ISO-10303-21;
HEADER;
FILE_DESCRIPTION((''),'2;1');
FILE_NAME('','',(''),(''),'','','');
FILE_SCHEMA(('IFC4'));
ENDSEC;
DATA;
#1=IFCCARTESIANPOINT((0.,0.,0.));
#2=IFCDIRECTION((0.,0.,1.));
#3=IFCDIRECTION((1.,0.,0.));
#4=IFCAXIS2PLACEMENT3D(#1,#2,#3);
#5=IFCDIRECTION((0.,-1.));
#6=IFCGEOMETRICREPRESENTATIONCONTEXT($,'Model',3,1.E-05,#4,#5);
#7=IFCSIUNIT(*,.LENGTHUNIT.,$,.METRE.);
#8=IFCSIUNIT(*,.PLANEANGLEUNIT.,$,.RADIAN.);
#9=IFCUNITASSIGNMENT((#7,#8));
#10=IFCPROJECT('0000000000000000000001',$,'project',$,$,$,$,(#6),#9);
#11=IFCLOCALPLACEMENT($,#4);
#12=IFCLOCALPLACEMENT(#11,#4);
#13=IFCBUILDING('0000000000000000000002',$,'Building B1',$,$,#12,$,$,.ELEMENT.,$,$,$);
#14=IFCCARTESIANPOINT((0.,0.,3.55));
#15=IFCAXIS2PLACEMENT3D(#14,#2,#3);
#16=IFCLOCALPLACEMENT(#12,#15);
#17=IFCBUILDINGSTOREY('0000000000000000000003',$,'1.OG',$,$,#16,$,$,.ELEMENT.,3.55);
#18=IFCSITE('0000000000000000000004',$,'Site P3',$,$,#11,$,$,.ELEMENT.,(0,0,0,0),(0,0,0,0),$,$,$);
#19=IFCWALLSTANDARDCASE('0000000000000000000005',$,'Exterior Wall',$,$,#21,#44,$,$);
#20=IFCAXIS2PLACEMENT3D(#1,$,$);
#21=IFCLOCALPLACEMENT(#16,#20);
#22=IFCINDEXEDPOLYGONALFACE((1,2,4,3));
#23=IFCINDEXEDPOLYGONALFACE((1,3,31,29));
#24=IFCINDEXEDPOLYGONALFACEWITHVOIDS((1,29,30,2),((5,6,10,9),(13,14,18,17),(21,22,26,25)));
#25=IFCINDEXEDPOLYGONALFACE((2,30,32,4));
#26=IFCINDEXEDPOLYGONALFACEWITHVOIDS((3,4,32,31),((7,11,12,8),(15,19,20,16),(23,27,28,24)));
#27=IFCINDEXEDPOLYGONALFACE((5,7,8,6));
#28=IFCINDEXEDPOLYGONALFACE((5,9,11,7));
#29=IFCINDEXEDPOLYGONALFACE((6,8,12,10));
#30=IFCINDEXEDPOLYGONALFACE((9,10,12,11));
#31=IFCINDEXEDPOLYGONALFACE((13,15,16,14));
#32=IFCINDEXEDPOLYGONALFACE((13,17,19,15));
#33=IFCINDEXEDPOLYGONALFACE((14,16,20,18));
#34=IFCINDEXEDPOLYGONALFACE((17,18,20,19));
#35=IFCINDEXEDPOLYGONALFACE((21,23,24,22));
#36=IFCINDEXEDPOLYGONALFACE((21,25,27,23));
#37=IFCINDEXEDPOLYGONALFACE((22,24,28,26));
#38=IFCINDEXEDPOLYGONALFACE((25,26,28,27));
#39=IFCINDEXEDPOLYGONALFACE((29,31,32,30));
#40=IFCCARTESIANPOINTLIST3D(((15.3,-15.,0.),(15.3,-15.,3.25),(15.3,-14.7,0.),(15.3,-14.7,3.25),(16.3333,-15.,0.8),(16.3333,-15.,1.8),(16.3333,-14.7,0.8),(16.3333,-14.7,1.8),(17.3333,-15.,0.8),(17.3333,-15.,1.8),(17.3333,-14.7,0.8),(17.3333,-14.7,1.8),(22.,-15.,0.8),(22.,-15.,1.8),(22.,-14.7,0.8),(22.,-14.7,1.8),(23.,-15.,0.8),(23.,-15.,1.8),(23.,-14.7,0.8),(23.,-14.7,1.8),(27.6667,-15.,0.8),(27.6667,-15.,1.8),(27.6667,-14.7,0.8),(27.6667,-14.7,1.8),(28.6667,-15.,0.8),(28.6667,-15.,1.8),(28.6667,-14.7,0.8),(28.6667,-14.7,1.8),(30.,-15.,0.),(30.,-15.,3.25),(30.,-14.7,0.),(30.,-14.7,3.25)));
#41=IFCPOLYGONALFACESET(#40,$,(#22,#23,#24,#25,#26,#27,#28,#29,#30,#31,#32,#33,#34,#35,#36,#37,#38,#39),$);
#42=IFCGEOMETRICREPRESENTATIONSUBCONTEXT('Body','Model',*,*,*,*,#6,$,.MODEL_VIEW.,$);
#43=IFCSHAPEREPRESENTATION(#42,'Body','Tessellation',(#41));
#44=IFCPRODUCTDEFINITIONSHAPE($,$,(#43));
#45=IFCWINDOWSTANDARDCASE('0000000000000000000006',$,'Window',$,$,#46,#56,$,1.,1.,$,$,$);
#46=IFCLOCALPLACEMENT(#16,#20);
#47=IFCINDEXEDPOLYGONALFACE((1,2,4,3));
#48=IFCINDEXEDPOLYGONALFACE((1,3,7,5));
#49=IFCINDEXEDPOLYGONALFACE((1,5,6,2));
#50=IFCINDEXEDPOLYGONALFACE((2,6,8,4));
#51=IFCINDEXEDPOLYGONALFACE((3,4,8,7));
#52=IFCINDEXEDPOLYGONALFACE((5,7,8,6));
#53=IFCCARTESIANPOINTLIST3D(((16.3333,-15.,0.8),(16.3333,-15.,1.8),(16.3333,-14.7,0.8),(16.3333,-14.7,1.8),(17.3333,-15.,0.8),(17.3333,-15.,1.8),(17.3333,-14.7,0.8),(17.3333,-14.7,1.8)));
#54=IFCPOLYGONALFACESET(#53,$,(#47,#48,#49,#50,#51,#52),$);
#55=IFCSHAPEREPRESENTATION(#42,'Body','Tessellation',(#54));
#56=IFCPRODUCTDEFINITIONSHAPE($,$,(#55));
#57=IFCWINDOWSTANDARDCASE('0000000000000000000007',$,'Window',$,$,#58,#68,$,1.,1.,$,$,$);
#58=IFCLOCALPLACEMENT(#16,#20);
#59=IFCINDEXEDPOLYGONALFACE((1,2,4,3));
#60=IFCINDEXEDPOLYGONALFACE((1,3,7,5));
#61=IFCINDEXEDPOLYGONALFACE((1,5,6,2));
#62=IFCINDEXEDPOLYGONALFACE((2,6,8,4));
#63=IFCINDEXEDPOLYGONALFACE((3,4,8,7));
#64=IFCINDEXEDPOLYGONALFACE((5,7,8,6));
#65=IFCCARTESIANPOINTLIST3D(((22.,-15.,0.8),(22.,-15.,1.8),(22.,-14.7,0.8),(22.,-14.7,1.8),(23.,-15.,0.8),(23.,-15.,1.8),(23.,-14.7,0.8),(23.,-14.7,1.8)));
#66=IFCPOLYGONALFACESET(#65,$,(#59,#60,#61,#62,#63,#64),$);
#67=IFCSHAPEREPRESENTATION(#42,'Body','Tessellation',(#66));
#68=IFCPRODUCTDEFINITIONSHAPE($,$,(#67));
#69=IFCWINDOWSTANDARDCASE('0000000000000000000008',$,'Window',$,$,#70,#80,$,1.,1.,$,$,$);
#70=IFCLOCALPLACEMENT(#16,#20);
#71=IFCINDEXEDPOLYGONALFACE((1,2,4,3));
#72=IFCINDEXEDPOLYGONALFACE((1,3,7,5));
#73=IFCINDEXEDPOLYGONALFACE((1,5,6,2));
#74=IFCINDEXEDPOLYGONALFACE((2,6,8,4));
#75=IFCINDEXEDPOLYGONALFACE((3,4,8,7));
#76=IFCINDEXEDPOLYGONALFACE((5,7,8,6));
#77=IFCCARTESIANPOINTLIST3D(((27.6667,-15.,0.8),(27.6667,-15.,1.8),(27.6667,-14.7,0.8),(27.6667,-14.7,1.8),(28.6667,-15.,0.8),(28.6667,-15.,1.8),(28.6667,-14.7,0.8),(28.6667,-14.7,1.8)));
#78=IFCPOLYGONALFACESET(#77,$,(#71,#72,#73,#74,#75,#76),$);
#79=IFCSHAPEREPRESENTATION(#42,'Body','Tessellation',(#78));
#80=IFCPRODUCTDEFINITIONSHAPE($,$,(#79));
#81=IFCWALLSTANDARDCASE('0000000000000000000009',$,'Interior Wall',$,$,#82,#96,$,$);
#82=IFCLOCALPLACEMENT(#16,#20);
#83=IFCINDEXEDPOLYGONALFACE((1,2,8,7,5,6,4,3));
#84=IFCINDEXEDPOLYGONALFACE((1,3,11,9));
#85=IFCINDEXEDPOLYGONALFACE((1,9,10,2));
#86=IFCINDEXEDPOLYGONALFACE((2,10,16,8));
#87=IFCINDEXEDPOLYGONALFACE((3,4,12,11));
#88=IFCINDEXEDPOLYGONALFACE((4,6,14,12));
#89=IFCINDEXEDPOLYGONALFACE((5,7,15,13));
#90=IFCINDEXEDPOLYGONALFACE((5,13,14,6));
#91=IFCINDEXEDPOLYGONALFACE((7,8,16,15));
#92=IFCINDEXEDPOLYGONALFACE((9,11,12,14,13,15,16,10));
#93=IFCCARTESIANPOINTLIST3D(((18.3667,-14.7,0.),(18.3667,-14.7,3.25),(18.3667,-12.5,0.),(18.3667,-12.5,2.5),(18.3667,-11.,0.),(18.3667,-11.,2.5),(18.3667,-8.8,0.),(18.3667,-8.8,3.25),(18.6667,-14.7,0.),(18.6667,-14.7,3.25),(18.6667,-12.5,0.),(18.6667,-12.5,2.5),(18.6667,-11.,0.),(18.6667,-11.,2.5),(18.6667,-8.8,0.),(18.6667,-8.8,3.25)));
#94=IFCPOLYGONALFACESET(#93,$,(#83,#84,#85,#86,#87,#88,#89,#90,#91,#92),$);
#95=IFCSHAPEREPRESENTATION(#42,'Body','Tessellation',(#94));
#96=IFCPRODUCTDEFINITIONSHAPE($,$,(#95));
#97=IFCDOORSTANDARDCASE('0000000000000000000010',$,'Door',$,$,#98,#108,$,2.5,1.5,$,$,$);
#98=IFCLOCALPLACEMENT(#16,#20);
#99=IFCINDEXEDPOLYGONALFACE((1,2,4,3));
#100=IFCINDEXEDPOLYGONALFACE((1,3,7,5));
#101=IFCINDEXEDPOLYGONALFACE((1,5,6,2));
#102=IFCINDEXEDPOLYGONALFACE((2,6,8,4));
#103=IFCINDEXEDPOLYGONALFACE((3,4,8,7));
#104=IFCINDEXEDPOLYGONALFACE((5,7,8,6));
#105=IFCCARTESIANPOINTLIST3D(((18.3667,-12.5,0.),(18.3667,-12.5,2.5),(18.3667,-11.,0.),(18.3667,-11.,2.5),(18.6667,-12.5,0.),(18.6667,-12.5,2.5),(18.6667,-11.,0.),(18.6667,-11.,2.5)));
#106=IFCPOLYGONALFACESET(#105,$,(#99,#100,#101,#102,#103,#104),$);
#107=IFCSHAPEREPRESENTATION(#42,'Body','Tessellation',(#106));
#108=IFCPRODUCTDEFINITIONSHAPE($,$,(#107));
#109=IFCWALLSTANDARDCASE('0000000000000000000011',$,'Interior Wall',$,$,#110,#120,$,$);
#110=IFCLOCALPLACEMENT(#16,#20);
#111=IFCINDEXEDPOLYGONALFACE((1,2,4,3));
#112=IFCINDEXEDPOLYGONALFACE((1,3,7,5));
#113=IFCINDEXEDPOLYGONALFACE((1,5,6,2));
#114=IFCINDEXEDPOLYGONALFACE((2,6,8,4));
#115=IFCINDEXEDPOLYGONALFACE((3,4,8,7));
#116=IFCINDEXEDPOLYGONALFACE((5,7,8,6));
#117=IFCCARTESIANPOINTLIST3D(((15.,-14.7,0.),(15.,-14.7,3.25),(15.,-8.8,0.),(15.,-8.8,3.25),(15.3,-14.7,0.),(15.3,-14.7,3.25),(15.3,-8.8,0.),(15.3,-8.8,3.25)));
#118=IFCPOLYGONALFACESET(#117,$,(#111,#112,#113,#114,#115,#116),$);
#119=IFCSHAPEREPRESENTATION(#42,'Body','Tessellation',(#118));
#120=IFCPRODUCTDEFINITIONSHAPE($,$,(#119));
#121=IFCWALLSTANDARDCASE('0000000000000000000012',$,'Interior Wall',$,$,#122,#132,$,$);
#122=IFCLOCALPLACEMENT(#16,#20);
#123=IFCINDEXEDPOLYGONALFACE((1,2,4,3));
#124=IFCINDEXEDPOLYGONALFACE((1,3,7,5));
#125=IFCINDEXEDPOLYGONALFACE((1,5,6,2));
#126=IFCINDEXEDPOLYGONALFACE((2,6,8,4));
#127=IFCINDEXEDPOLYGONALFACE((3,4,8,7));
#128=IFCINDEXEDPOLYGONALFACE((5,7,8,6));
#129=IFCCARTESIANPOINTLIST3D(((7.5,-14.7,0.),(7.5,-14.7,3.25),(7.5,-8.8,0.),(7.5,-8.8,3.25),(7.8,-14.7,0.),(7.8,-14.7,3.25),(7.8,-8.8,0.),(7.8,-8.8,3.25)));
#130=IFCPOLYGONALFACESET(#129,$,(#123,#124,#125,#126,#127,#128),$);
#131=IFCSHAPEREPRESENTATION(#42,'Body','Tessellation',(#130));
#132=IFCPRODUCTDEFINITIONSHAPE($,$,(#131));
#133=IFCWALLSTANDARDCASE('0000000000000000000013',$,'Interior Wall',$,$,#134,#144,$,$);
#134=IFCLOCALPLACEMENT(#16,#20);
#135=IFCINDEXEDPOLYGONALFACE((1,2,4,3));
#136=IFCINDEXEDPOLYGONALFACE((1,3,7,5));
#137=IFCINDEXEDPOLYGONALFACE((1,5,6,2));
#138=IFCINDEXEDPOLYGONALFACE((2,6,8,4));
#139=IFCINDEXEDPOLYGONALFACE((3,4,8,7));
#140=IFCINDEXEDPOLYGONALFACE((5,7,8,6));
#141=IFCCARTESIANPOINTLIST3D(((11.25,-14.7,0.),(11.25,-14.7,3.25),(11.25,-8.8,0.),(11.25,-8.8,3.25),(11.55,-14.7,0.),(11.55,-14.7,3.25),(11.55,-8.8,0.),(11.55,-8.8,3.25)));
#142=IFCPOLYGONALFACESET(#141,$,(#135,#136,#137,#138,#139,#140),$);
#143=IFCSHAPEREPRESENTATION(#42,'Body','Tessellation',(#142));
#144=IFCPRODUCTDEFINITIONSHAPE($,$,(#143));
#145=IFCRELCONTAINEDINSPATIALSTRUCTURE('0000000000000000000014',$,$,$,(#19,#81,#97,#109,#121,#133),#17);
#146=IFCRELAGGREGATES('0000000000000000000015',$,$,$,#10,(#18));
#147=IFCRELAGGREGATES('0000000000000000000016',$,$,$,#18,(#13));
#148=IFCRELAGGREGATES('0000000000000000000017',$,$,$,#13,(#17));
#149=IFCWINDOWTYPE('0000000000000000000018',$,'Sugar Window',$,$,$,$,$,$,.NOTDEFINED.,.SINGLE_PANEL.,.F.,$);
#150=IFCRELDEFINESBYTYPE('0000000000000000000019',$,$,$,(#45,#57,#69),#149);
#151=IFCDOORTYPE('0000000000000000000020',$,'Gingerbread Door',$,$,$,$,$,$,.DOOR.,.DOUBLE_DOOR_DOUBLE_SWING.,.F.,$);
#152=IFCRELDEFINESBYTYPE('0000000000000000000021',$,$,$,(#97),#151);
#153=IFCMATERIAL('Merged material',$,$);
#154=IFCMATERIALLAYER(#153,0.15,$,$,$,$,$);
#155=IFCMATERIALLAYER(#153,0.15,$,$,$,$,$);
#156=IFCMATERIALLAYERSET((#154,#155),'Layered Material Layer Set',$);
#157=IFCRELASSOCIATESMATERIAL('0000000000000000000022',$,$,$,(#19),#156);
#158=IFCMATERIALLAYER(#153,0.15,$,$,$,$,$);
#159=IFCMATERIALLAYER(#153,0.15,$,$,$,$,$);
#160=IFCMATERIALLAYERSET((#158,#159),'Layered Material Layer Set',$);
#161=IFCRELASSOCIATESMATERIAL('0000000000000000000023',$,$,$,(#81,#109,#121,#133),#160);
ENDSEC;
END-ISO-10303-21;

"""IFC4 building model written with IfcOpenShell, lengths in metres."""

from ifc_helpers import new_model, si_unit, direction, frame, origin_with_axes, place, context, subcontext, project, spatial, polyline, outline, extrude, source, transform, mapped, material, layer, layer_set, layer_usage, type_object, element, fill, save


model = new_model("IFC4")

# Units and contexts
model_context = context("Model", 3, precision=1e-05, world=origin_with_axes(), true_north=direction((0.0, -1.0)))
body_context = subcontext(model_context, "Body", "Model", "MODEL_VIEW")
ifc_project = project(units=[si_unit("LENGTHUNIT", "METRE"), si_unit("PLANEANGLEUNIT", "RADIAN")], contexts=[model_context])

# Site, building, storey
site_placement = place(None, origin_with_axes())
site = spatial("IfcSite", under=ifc_project, at=site_placement, Name="Site P3", CompositionType="ELEMENT", RefLatitude=(0, 0, 0, 0), RefLongitude=(0, 0, 0, 0))
building_placement = place(site_placement, origin_with_axes())
building = spatial("IfcBuilding", under=site, at=building_placement, Name="Building B1", CompositionType="ELEMENT")
storey_placement = place(building_placement, frame((0.0, 0.0, 3.55), z_axis=(0.0, 0.0, 1.0), x_axis=(1.0, 0.0, 0.0)))
storey = spatial("IfcBuildingStorey", under=building, at=storey_placement, Name="1.OG", CompositionType="ELEMENT", Elevation=3.55)

# Wall, openings, windows
ifc_material = material(Name="Merged material")
ifc_layer_1 = layer(ifc_material, 0.15)
ifc_layer_2 = layer(ifc_material, 0.15)
ifc_layer_set_1 = layer_set([ifc_layer_1, ifc_layer_2], Name="Layered Material Layer Set")
ifc_layer_usage_1 = layer_usage(ifc_layer_set_1, "AXIS2", "POSITIVE", -0.15)
wall_1_placement = place(storey_placement, frame((15.3, -14.85, 0.0), z_axis=(0.0, 0.0, 1.0), x_axis=(1.0, 0.0, 0.0)))
wall_1 = element("IfcWallStandardCase", 1, at=wall_1_placement, inside=storey, material=ifc_layer_usage_1, Name="Exterior Wall", context=body_context, shape_type="SweptSolid", body=[
    extrude(outline(polyline([(0.0, 0.15), (14.7, 0.15), (14.7, -0.15), (0.0, -0.15), (0.0, 0.15)])), origin_with_axes(), (0.0, 0.0, 1.0), 3.25),
])
opening_1_placement = place(wall_1_placement, frame((1.0333, 0.0, 0.8), z_axis=(0.0, 0.0, 1.0), x_axis=(1.0, 0.0, 0.0)))
opening_1 = element("IfcOpeningStandardCase", 2, at=opening_1_placement, cuts=wall_1, context=body_context, shape_type="SweptSolid", body=[
    extrude(outline(polyline([(0.0, 0.0), (0.0, 1.0), (1.0, 1.0), (1.0, 0.0), (0.0, 0.0)])), frame((0.0, -0.15, 0.0), z_axis=(0.0, 1.0, 0.0), x_axis=(0.0, 0.0, 1.0)), (0.0, 0.0, 1.0), 0.3),
])
opening_2_placement = place(wall_1_placement, frame((6.7, 0.0, 0.8), z_axis=(0.0, 0.0, 1.0), x_axis=(1.0, 0.0, 0.0)))
opening_2 = element("IfcOpeningStandardCase", 3, at=opening_2_placement, cuts=wall_1, context=body_context, shape_type="SweptSolid", body=[
    extrude(outline(polyline([(0.0, 0.0), (0.0, 1.0), (1.0, 1.0), (1.0, 0.0), (0.0, 0.0)])), frame((0.0, -0.15, 0.0), z_axis=(0.0, 1.0, 0.0), x_axis=(0.0, 0.0, 1.0)), (0.0, 0.0, 1.0), 0.3),
])
opening_3_placement = place(wall_1_placement, frame((12.3667, 0.0, 0.8), z_axis=(0.0, 0.0, 1.0), x_axis=(1.0, 0.0, 0.0)))
opening_3 = element("IfcOpeningStandardCase", 4, at=opening_3_placement, cuts=wall_1, context=body_context, shape_type="SweptSolid", body=[
    extrude(outline(polyline([(0.0, 0.0), (0.0, 1.0), (1.0, 1.0), (1.0, 0.0), (0.0, 0.0)])), frame((0.0, -0.15, 0.0), z_axis=(0.0, 1.0, 0.0), x_axis=(0.0, 0.0, 1.0)), (0.0, 0.0, 1.0), 0.3),
])
window_type = type_object("IfcWindowType", Name="Sugar Window", ParameterTakesPrecedence=False, PartitioningType="SINGLE_PANEL", PredefinedType="NOTDEFINED")
shared_shape_1 = source(origin_with_axes(), body_context, "Body", "SweptSolid", [
    extrude(outline(polyline([(0.0, 0.0), (0.0, 1.0), (1.0, 1.0), (1.0, 0.0), (0.0, 0.0)])), frame((0.0, -0.15, 0.0), z_axis=(0.0, 1.0, 0.0), x_axis=(0.0, 0.0, 1.0)), (0.0, 0.0, 1.0), 0.3),
])
window_1_placement = place(opening_1_placement, origin_with_axes())
window_1 = element("IfcWindowStandardCase", 5, at=window_1_placement, type_object=window_type, Name="Window", OverallHeight=1.0, OverallWidth=1.0, context=body_context, shape_type="MappedRepresentation", body=[
    mapped(shared_shape_1, transform((0.0, 0.0, 0.0))),
])
fill(opening_1, window_1)
window_2_placement = place(opening_2_placement, origin_with_axes())
window_2 = element("IfcWindowStandardCase", 6, at=window_2_placement, type_object=window_type, Name="Window", OverallHeight=1.0, OverallWidth=1.0, context=body_context, shape_type="MappedRepresentation", body=[
    mapped(shared_shape_1, transform((0.0, 0.0, 0.0))),
])
fill(opening_2, window_2)
window_3_placement = place(opening_3_placement, origin_with_axes())
window_3 = element("IfcWindowStandardCase", 7, at=window_3_placement, type_object=window_type, Name="Window", OverallHeight=1.0, OverallWidth=1.0, context=body_context, shape_type="MappedRepresentation", body=[
    mapped(shared_shape_1, transform((0.0, 0.0, 0.0))),
])
fill(opening_3, window_3)

# Wall, opening, door
ifc_layer_3 = layer(ifc_material, 0.15)
ifc_layer_4 = layer(ifc_material, 0.15)
ifc_layer_set_2 = layer_set([ifc_layer_3, ifc_layer_4], Name="Layered Material Layer Set")
ifc_layer_usage_2 = layer_usage(ifc_layer_set_2, "AXIS2", "POSITIVE", -0.15)
wall_2_placement = place(storey_placement, frame((18.5167, -8.8, 0.0), z_axis=(0.0, 0.0, 1.0), x_axis=(0.0, -1.0, 0.0)))
wall_2 = element("IfcWallStandardCase", 8, at=wall_2_placement, inside=storey, material=ifc_layer_usage_2, Name="Interior Wall", context=body_context, shape_type="SweptSolid", body=[
    extrude(outline(polyline([(0.0, 0.15), (5.9, 0.15), (5.9, -0.15), (0.0, -0.15), (0.0, 0.15)])), origin_with_axes(), (0.0, 0.0, 1.0), 3.25),
])
opening_4_placement = place(wall_2_placement, frame((2.2, 0.0, 0.0), z_axis=(0.0, 0.0, 1.0), x_axis=(1.0, 0.0, 0.0)))
opening_4 = element("IfcOpeningStandardCase", 9, at=opening_4_placement, cuts=wall_2, context=body_context, shape_type="SweptSolid", body=[
    extrude(outline(polyline([(0.0, 0.0), (0.0, 1.5), (2.5, 1.5), (2.5, 0.0), (0.0, 0.0)])), frame((0.0, -0.15, 0.0), z_axis=(0.0, 1.0, 0.0), x_axis=(0.0, 0.0, 1.0)), (0.0, 0.0, 1.0), 0.3),
])
door_type = type_object("IfcDoorType", Name="Gingerbread Door", OperationType="DOUBLE_DOOR_DOUBLE_SWING", ParameterTakesPrecedence=False, PredefinedType="DOOR")
shared_shape_2 = source(origin_with_axes(), body_context, "Body", "SweptSolid", [
    extrude(outline(polyline([(0.0, 0.0), (0.0, 1.5), (2.5, 1.5), (2.5, 0.0), (0.0, 0.0)])), frame((0.0, -0.15, 0.0), z_axis=(0.0, 1.0, 0.0), x_axis=(0.0, 0.0, 1.0)), (0.0, 0.0, 1.0), 0.3),
])
door_placement = place(opening_4_placement, origin_with_axes())
door = element("IfcDoorStandardCase", 10, at=door_placement, inside=storey, type_object=door_type, Name="Door", OverallHeight=2.5, OverallWidth=1.5, context=body_context, shape_type="MappedRepresentation", body=[
    mapped(shared_shape_2, transform((0.0, 0.0, 0.0))),
])
fill(opening_4, door)

# Walls
for number, where, z_axis, x_axis, name in (
    (11, (15.15, -8.8, 0.0), (0.0, 0.0, 1.0), (0.0, -1.0, 0.0), "Interior Wall"),
    (12, (7.65, -8.8, 0.0), (0.0, 0.0, 1.0), (0.0, -1.0, 0.0), "Interior Wall"),
    (13, (11.4, -8.8, 0.0), (0.0, 0.0, 1.0), (0.0, -1.0, 0.0), "Interior Wall"),
):
    element("IfcWallStandardCase", number, at=place(storey_placement, frame(where, z_axis=z_axis, x_axis=x_axis)), inside=storey, material=ifc_layer_usage_2, Name=name, context=body_context, shape_type="SweptSolid", body=[
        extrude(outline(polyline([(0.0, 0.15), (5.9, 0.15), (5.9, -0.15), (0.0, -0.15), (0.0, 0.15)])), origin_with_axes(), (0.0, 0.0, 1.0), 3.25),
    ])

save(model, "model.ifc")
